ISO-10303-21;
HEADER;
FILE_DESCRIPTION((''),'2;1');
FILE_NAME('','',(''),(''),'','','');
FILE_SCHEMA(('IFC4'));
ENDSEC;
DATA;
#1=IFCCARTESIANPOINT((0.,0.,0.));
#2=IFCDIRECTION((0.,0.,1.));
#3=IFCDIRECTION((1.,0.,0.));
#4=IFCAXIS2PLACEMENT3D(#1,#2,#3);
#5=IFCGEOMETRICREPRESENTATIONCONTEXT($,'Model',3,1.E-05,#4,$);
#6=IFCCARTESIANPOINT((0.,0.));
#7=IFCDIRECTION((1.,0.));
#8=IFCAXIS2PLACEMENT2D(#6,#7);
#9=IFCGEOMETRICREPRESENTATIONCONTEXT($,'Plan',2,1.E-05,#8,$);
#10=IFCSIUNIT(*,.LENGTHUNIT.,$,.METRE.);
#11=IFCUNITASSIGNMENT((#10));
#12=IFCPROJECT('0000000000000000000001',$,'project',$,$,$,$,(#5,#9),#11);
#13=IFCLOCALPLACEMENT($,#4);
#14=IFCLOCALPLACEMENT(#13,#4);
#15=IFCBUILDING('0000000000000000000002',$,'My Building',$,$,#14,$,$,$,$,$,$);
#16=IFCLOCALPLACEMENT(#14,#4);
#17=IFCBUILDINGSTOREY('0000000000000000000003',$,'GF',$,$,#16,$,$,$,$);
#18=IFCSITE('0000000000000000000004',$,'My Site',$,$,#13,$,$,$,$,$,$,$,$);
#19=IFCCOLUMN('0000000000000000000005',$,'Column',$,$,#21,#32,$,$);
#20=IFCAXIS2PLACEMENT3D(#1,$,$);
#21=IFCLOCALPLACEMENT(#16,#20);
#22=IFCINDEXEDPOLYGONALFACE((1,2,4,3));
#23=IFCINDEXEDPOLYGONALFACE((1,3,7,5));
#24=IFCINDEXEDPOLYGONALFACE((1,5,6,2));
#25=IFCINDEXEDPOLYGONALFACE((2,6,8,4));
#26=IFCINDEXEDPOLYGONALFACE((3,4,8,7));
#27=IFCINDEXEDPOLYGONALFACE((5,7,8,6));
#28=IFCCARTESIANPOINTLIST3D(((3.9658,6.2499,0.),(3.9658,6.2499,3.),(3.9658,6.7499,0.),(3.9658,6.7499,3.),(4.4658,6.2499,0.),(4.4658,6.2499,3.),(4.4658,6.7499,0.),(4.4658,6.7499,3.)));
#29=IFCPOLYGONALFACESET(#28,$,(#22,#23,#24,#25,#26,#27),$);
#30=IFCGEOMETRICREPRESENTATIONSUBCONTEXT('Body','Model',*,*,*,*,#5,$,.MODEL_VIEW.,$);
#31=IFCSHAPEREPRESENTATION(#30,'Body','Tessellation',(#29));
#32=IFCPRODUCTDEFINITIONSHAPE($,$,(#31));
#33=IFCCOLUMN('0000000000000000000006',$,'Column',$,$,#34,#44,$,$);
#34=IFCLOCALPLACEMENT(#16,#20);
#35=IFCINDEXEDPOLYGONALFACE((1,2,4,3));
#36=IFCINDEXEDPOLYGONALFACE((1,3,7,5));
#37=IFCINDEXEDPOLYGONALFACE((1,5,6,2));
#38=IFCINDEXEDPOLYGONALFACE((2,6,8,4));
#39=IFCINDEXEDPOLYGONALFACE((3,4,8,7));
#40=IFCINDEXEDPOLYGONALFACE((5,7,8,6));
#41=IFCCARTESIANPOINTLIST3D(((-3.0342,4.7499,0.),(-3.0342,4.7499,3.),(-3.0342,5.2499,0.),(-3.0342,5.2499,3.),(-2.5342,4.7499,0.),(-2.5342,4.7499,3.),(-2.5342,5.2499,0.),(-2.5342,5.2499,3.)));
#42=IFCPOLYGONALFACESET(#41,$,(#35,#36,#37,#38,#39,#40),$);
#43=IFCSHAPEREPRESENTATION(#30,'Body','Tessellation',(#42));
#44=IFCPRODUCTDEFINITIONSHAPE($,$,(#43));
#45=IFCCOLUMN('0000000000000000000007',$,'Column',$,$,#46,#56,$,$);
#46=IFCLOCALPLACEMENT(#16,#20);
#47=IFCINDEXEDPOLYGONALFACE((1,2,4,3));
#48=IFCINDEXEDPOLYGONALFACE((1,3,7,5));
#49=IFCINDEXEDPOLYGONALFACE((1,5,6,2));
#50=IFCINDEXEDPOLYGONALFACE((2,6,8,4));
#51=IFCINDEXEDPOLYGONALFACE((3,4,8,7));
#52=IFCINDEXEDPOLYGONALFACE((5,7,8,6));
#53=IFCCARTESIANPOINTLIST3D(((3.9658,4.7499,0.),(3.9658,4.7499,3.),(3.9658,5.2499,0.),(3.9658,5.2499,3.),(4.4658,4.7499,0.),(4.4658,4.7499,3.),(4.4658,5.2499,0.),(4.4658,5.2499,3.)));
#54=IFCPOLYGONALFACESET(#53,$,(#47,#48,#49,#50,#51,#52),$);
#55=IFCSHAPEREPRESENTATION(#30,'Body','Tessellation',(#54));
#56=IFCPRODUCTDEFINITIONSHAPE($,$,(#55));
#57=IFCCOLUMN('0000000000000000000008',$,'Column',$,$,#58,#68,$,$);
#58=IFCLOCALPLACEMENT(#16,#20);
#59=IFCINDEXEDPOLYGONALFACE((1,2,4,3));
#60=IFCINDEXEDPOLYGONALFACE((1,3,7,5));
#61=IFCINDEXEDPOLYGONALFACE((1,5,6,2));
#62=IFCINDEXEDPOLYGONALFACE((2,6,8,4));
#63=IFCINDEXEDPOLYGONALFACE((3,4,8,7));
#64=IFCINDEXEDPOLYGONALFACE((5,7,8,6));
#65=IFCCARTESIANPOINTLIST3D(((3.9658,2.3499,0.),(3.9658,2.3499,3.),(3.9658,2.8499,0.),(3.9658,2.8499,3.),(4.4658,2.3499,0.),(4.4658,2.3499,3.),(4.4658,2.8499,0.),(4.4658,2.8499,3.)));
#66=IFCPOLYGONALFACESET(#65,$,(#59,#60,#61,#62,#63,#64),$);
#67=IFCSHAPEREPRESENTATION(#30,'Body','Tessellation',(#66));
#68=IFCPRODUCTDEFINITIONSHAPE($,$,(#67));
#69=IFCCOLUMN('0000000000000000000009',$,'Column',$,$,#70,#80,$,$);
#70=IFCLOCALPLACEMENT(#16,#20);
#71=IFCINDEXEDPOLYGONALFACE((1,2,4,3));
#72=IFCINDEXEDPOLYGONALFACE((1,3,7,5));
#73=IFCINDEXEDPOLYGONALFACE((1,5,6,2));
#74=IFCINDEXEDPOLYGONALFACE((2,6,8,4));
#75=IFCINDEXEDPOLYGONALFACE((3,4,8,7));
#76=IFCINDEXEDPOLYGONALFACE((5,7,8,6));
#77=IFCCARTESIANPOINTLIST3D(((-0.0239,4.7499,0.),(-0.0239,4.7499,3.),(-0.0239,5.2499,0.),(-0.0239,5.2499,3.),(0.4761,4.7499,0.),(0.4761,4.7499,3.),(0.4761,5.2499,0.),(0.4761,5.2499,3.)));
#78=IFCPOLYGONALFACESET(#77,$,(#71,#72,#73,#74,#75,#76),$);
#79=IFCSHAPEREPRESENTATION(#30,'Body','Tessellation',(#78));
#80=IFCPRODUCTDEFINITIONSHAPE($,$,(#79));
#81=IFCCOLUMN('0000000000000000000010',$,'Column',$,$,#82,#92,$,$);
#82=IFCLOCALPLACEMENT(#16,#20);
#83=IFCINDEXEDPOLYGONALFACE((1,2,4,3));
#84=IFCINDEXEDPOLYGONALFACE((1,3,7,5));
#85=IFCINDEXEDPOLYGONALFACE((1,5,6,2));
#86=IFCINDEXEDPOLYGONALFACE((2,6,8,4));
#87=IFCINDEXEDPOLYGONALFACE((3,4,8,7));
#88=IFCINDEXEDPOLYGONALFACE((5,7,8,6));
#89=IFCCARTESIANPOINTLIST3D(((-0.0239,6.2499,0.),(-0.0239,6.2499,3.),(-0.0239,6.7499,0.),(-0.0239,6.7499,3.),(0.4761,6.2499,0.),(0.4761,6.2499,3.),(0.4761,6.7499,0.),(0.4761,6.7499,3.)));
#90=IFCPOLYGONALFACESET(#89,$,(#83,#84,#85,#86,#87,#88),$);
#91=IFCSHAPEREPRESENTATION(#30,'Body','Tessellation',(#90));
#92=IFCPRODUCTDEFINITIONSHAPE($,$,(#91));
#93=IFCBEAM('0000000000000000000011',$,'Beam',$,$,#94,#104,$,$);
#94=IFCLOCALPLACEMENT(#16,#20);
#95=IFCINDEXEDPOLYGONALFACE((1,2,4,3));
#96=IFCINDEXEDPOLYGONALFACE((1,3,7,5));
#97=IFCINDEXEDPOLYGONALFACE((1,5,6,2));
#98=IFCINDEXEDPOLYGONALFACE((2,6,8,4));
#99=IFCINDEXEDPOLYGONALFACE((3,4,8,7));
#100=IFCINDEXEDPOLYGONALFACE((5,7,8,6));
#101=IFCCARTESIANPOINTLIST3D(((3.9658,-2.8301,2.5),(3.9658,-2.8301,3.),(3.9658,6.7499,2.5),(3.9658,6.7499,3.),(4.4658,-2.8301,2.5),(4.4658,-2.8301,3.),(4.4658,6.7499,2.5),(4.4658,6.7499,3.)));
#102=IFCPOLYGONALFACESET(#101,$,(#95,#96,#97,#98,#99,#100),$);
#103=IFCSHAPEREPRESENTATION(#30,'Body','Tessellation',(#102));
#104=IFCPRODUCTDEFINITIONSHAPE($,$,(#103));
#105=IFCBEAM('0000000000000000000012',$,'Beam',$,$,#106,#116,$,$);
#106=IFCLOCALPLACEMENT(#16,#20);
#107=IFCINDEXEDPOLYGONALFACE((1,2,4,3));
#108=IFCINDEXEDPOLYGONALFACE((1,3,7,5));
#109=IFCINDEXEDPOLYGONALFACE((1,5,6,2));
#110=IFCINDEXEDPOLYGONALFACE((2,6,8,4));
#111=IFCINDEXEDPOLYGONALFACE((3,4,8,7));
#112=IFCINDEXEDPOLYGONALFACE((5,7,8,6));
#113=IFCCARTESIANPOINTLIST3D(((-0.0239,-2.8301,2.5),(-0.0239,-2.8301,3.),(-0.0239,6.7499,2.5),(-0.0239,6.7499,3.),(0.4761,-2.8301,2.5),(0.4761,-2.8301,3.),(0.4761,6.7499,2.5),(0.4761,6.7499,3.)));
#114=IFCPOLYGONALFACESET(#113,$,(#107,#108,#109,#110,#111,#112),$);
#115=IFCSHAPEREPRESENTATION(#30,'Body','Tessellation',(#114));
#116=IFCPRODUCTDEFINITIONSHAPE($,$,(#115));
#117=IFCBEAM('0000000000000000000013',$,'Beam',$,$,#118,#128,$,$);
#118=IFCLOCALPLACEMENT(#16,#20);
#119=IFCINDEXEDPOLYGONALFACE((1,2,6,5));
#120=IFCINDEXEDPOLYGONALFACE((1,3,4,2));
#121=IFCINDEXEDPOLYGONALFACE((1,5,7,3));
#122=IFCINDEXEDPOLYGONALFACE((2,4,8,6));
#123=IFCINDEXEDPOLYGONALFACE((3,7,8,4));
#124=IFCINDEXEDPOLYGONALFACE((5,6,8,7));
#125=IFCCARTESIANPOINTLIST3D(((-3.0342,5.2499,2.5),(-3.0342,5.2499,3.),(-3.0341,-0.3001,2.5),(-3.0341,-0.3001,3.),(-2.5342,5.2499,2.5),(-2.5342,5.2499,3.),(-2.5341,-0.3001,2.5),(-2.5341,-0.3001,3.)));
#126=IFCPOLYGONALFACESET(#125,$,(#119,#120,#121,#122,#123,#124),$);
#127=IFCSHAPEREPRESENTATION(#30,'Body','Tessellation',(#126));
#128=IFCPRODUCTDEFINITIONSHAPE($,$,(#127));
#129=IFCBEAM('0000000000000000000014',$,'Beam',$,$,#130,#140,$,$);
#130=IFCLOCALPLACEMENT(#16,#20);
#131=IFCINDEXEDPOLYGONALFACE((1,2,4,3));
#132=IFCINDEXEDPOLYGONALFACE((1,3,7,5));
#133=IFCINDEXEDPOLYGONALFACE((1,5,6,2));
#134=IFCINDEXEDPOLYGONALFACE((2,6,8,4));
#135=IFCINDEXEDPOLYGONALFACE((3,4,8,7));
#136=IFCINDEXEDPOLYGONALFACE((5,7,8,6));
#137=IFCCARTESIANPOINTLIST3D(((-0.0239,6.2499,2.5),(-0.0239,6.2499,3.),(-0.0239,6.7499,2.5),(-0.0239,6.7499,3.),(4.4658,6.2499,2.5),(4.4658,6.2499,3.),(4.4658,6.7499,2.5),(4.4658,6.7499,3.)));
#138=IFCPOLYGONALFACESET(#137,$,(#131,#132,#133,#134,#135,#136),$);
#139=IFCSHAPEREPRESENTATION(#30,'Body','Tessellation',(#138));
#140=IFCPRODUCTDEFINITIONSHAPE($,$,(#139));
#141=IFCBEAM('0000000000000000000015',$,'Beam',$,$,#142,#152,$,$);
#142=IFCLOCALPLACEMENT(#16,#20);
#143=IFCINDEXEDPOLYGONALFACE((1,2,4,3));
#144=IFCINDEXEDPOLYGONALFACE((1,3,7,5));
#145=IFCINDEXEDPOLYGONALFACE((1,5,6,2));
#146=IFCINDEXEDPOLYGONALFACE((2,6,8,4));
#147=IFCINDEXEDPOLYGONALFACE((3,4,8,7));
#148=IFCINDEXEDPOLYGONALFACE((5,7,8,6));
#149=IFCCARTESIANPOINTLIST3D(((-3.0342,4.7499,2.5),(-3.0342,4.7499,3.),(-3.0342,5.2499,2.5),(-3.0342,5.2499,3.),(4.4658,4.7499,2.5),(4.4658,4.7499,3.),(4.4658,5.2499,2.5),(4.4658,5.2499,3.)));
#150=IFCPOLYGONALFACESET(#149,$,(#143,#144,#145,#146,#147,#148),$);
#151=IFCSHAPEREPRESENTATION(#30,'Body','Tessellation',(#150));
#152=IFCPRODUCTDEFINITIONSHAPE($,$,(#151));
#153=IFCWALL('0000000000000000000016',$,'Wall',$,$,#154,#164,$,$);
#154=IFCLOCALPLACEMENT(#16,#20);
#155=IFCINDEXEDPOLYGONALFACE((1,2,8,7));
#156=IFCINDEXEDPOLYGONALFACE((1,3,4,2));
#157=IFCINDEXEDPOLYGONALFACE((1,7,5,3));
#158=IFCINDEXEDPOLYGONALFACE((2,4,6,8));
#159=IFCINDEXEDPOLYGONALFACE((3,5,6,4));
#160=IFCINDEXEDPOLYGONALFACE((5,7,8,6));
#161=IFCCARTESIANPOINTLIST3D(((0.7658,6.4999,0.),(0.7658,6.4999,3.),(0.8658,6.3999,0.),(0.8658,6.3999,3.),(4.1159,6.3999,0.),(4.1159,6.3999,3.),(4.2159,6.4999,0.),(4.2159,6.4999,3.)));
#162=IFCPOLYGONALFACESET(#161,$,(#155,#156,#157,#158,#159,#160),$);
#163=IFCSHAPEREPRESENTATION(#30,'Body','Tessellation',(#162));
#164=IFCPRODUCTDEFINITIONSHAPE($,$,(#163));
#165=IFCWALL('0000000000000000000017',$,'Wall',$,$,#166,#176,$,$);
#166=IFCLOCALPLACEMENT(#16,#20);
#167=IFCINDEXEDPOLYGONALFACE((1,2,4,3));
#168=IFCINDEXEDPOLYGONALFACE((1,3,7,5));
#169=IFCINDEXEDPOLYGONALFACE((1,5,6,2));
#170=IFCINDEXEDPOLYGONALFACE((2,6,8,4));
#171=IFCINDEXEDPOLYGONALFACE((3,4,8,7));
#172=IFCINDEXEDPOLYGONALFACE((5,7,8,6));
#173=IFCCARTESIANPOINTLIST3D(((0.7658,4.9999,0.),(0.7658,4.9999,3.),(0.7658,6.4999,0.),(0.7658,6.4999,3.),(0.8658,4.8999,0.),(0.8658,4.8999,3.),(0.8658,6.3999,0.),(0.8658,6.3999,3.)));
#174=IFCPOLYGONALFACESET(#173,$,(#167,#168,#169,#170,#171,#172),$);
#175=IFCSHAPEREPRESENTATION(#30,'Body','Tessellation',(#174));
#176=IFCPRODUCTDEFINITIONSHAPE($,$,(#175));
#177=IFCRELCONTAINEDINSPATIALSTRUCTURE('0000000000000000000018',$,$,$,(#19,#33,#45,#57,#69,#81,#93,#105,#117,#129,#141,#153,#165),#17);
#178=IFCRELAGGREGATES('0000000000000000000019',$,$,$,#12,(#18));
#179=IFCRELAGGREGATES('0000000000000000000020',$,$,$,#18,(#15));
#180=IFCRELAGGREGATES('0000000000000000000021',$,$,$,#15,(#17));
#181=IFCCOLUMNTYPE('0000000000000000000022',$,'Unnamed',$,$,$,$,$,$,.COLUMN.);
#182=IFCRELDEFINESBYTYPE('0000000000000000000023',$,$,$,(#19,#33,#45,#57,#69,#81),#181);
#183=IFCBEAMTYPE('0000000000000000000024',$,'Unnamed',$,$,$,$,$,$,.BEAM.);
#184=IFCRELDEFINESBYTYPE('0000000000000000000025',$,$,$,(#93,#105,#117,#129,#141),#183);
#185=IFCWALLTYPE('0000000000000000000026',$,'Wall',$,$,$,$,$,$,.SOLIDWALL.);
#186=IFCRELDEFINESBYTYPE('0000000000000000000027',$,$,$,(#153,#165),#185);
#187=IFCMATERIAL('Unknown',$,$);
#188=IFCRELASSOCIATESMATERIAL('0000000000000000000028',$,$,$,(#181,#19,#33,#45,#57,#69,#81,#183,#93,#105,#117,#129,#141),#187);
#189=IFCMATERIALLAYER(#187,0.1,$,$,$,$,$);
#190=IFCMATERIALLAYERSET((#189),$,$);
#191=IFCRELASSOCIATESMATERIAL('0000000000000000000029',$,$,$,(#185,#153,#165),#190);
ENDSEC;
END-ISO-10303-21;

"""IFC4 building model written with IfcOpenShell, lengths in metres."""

from ifc_helpers import new_model, si_unit, frame, origin_with_axes, origin_2d_with_axis, place, context, subcontext, project, spatial, line, indexed_curve, rectangle, outline, extrude, material, layer, layer_set, layer_usage, material_profile, profile_set, profile_usage, type_object, element, save


model = new_model("IFC4")

# Units and contexts
model_context = context("Model", 3, precision=1e-05, world=origin_with_axes())
plan_context = context("Plan", 2, precision=1e-05, world=origin_2d_with_axis())
body_context_1 = subcontext(model_context, "Body", "Model", "MODEL_VIEW")
ifc_project = project(units=[si_unit("LENGTHUNIT", "METRE")], contexts=[model_context, plan_context])

# Site, building, storey
site_placement = place(None, origin_with_axes())
site = spatial("IfcSite", under=ifc_project, at=site_placement, Name="My Site")
building_placement = place(site_placement, origin_with_axes())
building = spatial("IfcBuilding", under=site, at=building_placement, Name="My Building")
storey_placement = place(building_placement, origin_with_axes())
storey = spatial("IfcBuildingStorey", under=building, at=storey_placement, Name="GF")

# Columns
ifc_material_1 = material(Name="Unknown")
ifc_material_profile_1 = material_profile(ifc_material_1, rectangle(XDim=0.5, YDim=0.5))
ifc_profile_set_1 = profile_set([ifc_material_profile_1])
ifc_profile_usage_1 = profile_usage(ifc_profile_set_1, cardinal=5)
column_type = type_object("IfcColumnType", Name="Unnamed", PredefinedType="COLUMN", material=ifc_profile_set_1)
column_1_placement = place(storey_placement, frame((4.2158, 6.4999, 0.0), z_axis=(0.0, 0.0, 1.0), x_axis=(1.0, 0.0, 0.0)))
element("IfcColumn", 1, at=column_1_placement, inside=storey, type_object=column_type, material=ifc_profile_usage_1, Name="Column", context=body_context_1, shape_type="SweptSolid", body=[
    extrude(rectangle(XDim=0.5, YDim=0.5), origin_with_axes(), (0.0, 0.0, 1.0), 3.0),
])
ifc_profile_usage_2 = profile_usage(ifc_profile_set_1, cardinal=5)
column_2_placement = place(storey_placement, frame((-2.7842, 4.9999, 0.0), z_axis=(0.0, 0.0, 1.0), x_axis=(1.0, 0.0, 0.0)))
element("IfcColumn", 2, at=column_2_placement, inside=storey, type_object=column_type, material=ifc_profile_usage_2, Name="Column", context=body_context_1, shape_type="SweptSolid", body=[
    extrude(rectangle(XDim=0.5, YDim=0.5), origin_with_axes(), (0.0, 0.0, 1.0), 3.0),
])
ifc_profile_usage_3 = profile_usage(ifc_profile_set_1, cardinal=5)
column_3_placement = place(storey_placement, frame((4.2158, 4.9999, 0.0), z_axis=(0.0, 0.0, 1.0), x_axis=(1.0, 0.0, 0.0)))
element("IfcColumn", 3, at=column_3_placement, inside=storey, type_object=column_type, material=ifc_profile_usage_3, Name="Column", context=body_context_1, shape_type="SweptSolid", body=[
    extrude(rectangle(XDim=0.5, YDim=0.5), origin_with_axes(), (0.0, 0.0, 1.0), 3.0),
])
ifc_profile_usage_4 = profile_usage(ifc_profile_set_1, cardinal=5)
column_4_placement = place(storey_placement, frame((4.2158, 2.5999, 0.0), z_axis=(0.0, 0.0, 1.0), x_axis=(1.0, 0.0, 0.0)))
element("IfcColumn", 4, at=column_4_placement, inside=storey, type_object=column_type, material=ifc_profile_usage_4, Name="Column", context=body_context_1, shape_type="SweptSolid", body=[
    extrude(rectangle(XDim=0.5, YDim=0.5), origin_with_axes(), (0.0, 0.0, 1.0), 3.0),
])
ifc_profile_usage_5 = profile_usage(ifc_profile_set_1, cardinal=5)
column_5_placement = place(storey_placement, frame((0.2261, 4.9999, 0.0), z_axis=(0.0, 0.0, 1.0), x_axis=(1.0, 0.0, 0.0)))
element("IfcColumn", 5, at=column_5_placement, inside=storey, type_object=column_type, material=ifc_profile_usage_5, Name="Column", context=body_context_1, shape_type="SweptSolid", body=[
    extrude(rectangle(XDim=0.5, YDim=0.5), origin_with_axes(), (0.0, 0.0, 1.0), 3.0),
])
ifc_profile_usage_6 = profile_usage(ifc_profile_set_1, cardinal=5)
column_6_placement = place(storey_placement, frame((0.2261, 6.4999, 0.0), z_axis=(0.0, 0.0, 1.0), x_axis=(1.0, 0.0, 0.0)))
element("IfcColumn", 6, at=column_6_placement, inside=storey, type_object=column_type, material=ifc_profile_usage_6, Name="Column", context=body_context_1, shape_type="SweptSolid", body=[
    extrude(rectangle(XDim=0.5, YDim=0.5), origin_with_axes(), (0.0, 0.0, 1.0), 3.0),
])

# Beams
ifc_material_profile_2 = material_profile(ifc_material_1, rectangle(XDim=0.5, YDim=0.5))
ifc_profile_set_2 = profile_set([ifc_material_profile_2])
ifc_profile_usage_7 = profile_usage(ifc_profile_set_2, cardinal=7)
beam_type = type_object("IfcBeamType", Name="Unnamed", PredefinedType="BEAM", material=ifc_profile_set_2)
beam_1_placement = place(storey_placement, frame((4.4658, 6.7499, 3.0), z_axis=(0.0, -1.0, 0.0), x_axis=(1.0, 0.0, 0.0)))
element("IfcBeam", 7, at=beam_1_placement, inside=storey, type_object=beam_type, material=ifc_profile_usage_7, Name="Beam", context=body_context_1, shape_type="SweptSolid", body=[
    extrude(rectangle(XDim=0.5, YDim=0.5), frame((-0.25, -0.25, 0.0), z_axis=(0.0, 0.0, 1.0), x_axis=(1.0, 0.0, 0.0)), (0.0, 0.0, 1.0), 9.58),
])
ifc_profile_usage_8 = profile_usage(ifc_profile_set_2, cardinal=7)
beam_2_placement = place(storey_placement, frame((0.4761, 6.7499, 3.0), z_axis=(0.0, -1.0, 0.0), x_axis=(1.0, 0.0, 0.0)))
element("IfcBeam", 8, at=beam_2_placement, inside=storey, type_object=beam_type, material=ifc_profile_usage_8, Name="Beam", context=body_context_1, shape_type="SweptSolid", body=[
    extrude(rectangle(XDim=0.5, YDim=0.5), frame((-0.25, -0.25, 0.0), z_axis=(0.0, 0.0, 1.0), x_axis=(1.0, 0.0, 0.0)), (0.0, 0.0, 1.0), 9.58),
])
ifc_profile_usage_9 = profile_usage(ifc_profile_set_2, cardinal=7)
beam_3_placement = place(storey_placement, frame((-2.5342, 5.2499, 3.0), z_axis=(0.0, -1.0, 0.0), x_axis=(1.0, 0.0, 0.0)))
element("IfcBeam", 9, at=beam_3_placement, inside=storey, type_object=beam_type, material=ifc_profile_usage_9, Name="Beam", context=body_context_1, shape_type="SweptSolid", body=[
    extrude(rectangle(XDim=0.5, YDim=0.5), frame((-0.25, -0.25, 0.0), z_axis=(0.0, 0.0, 1.0), x_axis=(1.0, 0.0, 0.0)), (0.0, 0.0, 1.0), 5.55),
])
ifc_profile_usage_10 = profile_usage(ifc_profile_set_2, cardinal=7)
beam_4_placement = place(storey_placement, frame((4.4658, 6.2499, 3.0), z_axis=(-1.0, 0.0, 0.0), x_axis=(0.0, -1.0, 0.0)))
element("IfcBeam", 10, at=beam_4_placement, inside=storey, type_object=beam_type, material=ifc_profile_usage_10, Name="Beam", context=body_context_1, shape_type="SweptSolid", body=[
    extrude(rectangle(XDim=0.5, YDim=0.5), frame((-0.25, -0.25, 0.0), z_axis=(0.0, 0.0, 1.0), x_axis=(1.0, 0.0, 0.0)), (0.0, 0.0, 1.0), 4.4897),
])
ifc_profile_usage_11 = profile_usage(ifc_profile_set_2, cardinal=7)
beam_5_placement = place(storey_placement, frame((4.4658, 4.7499, 3.0), z_axis=(-1.0, 0.0, 0.0), x_axis=(0.0, -1.0, 0.0)))
element("IfcBeam", 11, at=beam_5_placement, inside=storey, type_object=beam_type, material=ifc_profile_usage_11, Name="Beam", context=body_context_1, shape_type="SweptSolid", body=[
    extrude(rectangle(XDim=0.5, YDim=0.5), frame((-0.25, -0.25, 0.0), z_axis=(0.0, 0.0, 1.0), x_axis=(1.0, 0.0, 0.0)), (0.0, 0.0, 1.0), 7.5),
])

# Walls
ifc_layer_1 = layer(ifc_material_1, 0.1)
ifc_layer_set_1 = layer_set([ifc_layer_1])
ifc_layer_usage_1 = layer_usage(ifc_layer_set_1, "AXIS2", "POSITIVE", 0.0)
wall_type = type_object("IfcWallType", Name="Wall", PredefinedType="SOLIDWALL", material=ifc_layer_set_1)
wall_1_placement = place(storey_placement, frame((4.2159, 6.4999, 0.0), z_axis=(0.0, 0.0, 1.0), x_axis=(-1.0, 0.0, 0.0)))
element("IfcWall", 12, at=wall_1_placement, inside=storey, type_object=wall_type, material=ifc_layer_usage_1, Name="Wall", context=body_context_1, shape_type="SweptSolid", body=[
    extrude(outline(indexed_curve([(0.0, 0.0), (0.1, 0.1), (3.35, 0.1), (3.45, 0.0)], segments=[line(1, 2, 3, 4, 1)])), origin_with_axes(), (0.0, 0.0, 1.0), 3.0),
])
ifc_layer_usage_2 = layer_usage(ifc_layer_set_1, "AXIS2", "POSITIVE", 0.0)
wall_2_placement = place(storey_placement, frame((0.7658, 6.4999, 0.0), z_axis=(0.0, 0.0, 1.0), x_axis=(0.0, -1.0, 0.0)))
element("IfcWall", 13, at=wall_2_placement, inside=storey, type_object=wall_type, material=ifc_layer_usage_2, Name="Wall", context=body_context_1, shape_type="SweptSolid", body=[
    extrude(outline(indexed_curve([(0.0, 0.0), (0.1, 0.1), (1.6, 0.1), (1.5, 0.0)], segments=[line(1, 2, 3, 4, 1)])), origin_with_axes(), (0.0, 0.0, 1.0), 3.0),
])

save(model, "model.ifc")
